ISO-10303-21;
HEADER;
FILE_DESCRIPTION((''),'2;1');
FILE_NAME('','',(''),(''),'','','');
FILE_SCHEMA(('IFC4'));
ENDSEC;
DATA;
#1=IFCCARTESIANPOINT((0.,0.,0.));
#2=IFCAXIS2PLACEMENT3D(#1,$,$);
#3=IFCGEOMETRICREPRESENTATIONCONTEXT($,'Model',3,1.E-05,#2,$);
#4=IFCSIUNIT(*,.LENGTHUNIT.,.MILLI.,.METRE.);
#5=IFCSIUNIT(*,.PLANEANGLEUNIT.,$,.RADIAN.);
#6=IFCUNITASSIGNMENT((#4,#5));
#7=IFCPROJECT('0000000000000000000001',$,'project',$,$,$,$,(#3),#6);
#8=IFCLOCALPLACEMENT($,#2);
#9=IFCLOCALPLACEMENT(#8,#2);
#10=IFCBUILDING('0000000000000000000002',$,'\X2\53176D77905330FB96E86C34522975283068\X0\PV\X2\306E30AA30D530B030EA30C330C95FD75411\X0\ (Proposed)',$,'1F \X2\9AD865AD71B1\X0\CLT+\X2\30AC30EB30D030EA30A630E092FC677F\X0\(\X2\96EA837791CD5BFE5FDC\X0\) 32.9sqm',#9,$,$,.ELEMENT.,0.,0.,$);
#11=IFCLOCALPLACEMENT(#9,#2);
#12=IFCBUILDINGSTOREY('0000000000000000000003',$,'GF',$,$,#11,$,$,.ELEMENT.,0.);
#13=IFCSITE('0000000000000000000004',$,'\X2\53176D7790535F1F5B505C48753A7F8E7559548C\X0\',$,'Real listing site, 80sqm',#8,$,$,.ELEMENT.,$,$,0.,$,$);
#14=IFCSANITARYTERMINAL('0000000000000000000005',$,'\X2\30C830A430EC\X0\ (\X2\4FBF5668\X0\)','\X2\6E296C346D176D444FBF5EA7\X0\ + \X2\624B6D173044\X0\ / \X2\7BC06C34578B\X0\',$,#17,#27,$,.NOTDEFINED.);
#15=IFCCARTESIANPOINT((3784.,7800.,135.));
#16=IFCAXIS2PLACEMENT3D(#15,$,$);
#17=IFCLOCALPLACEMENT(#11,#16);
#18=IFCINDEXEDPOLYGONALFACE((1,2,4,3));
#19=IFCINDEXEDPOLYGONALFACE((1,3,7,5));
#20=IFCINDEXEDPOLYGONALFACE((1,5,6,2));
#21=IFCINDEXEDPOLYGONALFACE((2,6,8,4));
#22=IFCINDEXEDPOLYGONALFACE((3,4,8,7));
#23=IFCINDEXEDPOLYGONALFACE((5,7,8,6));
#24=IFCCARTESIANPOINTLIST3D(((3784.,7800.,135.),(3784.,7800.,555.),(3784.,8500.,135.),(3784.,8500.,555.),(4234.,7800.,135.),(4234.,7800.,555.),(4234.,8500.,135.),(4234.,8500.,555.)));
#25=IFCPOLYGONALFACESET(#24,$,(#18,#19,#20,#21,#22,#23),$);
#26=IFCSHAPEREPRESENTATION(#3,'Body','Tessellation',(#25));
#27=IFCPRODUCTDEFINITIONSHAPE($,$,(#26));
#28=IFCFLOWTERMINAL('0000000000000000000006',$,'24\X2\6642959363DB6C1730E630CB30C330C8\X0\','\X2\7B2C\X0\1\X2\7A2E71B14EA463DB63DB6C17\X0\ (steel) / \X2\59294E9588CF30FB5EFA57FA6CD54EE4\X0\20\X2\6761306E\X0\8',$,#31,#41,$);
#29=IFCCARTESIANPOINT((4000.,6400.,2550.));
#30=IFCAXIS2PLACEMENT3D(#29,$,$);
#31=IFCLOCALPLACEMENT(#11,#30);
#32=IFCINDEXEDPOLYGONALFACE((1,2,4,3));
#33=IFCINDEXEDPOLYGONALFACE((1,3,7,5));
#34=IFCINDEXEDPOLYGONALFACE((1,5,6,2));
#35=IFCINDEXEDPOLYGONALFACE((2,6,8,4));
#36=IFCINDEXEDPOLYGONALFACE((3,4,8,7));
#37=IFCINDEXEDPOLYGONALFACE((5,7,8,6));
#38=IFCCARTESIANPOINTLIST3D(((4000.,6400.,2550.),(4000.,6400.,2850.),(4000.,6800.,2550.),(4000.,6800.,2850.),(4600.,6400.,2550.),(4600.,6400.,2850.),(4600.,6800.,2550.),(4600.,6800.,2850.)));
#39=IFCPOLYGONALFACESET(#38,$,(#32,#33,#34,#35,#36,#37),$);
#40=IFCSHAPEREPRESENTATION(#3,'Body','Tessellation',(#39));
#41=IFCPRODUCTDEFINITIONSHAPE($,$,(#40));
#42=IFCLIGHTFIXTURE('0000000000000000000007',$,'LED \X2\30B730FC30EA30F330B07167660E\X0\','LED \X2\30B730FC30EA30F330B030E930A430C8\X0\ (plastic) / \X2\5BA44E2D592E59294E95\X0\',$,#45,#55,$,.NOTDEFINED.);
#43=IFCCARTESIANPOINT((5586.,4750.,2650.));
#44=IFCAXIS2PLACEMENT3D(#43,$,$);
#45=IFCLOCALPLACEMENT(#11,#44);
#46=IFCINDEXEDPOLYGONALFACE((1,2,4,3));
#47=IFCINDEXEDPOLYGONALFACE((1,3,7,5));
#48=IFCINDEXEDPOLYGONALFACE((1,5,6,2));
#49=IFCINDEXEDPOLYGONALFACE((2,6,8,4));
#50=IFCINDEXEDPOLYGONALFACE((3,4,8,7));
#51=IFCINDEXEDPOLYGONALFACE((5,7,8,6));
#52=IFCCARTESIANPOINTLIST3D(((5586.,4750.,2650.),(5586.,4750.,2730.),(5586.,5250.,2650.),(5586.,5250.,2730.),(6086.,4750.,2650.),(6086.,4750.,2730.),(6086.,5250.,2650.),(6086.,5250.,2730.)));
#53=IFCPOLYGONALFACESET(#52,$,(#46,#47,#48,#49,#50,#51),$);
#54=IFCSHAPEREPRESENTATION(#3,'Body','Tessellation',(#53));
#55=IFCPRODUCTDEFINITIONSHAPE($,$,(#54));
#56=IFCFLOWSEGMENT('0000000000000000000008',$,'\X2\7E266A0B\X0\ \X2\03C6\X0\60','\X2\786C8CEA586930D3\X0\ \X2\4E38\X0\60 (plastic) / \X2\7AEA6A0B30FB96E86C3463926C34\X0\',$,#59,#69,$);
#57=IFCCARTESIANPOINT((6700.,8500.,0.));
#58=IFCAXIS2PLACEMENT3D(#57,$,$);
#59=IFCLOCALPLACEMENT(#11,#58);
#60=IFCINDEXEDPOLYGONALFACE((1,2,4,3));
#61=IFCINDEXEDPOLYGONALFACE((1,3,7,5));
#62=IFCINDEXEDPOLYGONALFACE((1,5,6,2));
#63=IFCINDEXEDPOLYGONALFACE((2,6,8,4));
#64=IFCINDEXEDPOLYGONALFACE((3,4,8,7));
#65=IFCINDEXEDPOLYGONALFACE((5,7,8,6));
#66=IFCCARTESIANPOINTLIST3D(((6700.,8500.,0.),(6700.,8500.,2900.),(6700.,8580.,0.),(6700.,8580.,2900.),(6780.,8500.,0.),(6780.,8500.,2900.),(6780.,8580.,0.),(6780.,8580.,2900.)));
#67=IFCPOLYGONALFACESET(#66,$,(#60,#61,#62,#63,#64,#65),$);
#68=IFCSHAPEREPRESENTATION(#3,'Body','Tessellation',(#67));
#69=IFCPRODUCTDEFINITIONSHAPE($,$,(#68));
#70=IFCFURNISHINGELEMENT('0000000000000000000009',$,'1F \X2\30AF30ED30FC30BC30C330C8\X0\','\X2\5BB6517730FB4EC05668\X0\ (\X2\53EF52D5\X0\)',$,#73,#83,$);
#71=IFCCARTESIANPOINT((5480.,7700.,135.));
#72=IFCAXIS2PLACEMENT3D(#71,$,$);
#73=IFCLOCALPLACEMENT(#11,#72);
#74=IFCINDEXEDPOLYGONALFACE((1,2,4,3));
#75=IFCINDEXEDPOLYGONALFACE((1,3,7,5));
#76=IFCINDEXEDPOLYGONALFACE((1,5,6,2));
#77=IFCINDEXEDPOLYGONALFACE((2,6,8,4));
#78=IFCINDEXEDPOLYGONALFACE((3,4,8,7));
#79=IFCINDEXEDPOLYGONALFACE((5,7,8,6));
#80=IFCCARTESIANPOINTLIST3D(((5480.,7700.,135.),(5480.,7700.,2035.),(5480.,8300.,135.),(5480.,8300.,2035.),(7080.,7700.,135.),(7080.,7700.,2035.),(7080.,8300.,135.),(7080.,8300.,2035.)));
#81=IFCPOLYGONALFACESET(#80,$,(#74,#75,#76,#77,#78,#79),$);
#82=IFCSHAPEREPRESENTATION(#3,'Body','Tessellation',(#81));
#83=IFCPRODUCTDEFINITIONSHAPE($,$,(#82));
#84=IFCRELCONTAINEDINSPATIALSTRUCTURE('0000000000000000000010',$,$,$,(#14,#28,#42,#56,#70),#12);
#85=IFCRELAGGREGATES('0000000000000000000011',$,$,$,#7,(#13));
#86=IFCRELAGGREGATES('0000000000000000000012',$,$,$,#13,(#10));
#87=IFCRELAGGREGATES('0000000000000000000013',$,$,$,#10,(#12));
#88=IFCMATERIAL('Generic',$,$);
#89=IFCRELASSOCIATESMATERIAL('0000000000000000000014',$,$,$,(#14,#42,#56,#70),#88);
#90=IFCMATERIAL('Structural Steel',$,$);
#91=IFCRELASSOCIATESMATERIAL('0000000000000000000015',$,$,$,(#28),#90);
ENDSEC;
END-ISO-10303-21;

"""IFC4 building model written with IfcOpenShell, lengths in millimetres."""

from ifc_helpers import new_model, si_unit, frame, frame_2d, origin, place, context, project, spatial, rectangle, extrude, material, element, save


model = new_model("IFC4")

# Units and contexts
model_context = context("Model", 3, precision=1e-05, world=origin())
ifc_project = project(units=[si_unit("LENGTHUNIT", "METRE", prefix="MILLI"), si_unit("PLANEANGLEUNIT", "RADIAN")], contexts=[model_context])

# Site, building, storey
site_placement = place(None, origin())
site = spatial("IfcSite", under=ifc_project, at=site_placement, Name="北海道弟子屈町美留和", ObjectType="Real listing site, 80sqm", CompositionType="ELEMENT", RefElevation=0.0)
building_placement = place(site_placement, origin())
building = spatial("IfcBuilding", under=site, at=building_placement, Name="北海道・雨水利用とPVのオフグリッド志向 (Proposed)", ObjectType="1F 高断熱CLT+ガルバリウム鋼板(雪荷重対応) 32.9sqm", CompositionType="ELEMENT", ElevationOfRefHeight=0.0, ElevationOfTerrain=0.0)
storey_placement = place(building_placement, origin())
storey = spatial("IfcBuildingStorey", under=building, at=storey_placement, Name="GF", CompositionType="ELEMENT", Elevation=0.0)

# Shared definitions
ifc_material_1 = material(Name="Generic")

# Sanitary terminal
sanitary_terminal_placement = place(storey_placement, frame((3784.0, 7800.0, 135.0)))
element("IfcSanitaryTerminal", 1, at=sanitary_terminal_placement, inside=storey, material=ifc_material_1, Name="トイレ (便器)", Description="温水洗浄便座 + 手洗い / 節水型", PredefinedType="NOTDEFINED", context=model_context, shape_type="SweptSolid", body=[
    extrude(rectangle(XDim=450.0, YDim=700.0, at=frame_2d((225.0, 350.0))), frame((3784.0, 7800.0, 135.0)), (0.0, 0.0, 1.0), 420.0),
])

# Flow terminal
ifc_material_2 = material(Name="Structural Steel")
flow_terminal_placement = place(storey_placement, frame((4000.0, 6400.0, 2550.0)))
element("IfcFlowTerminal", 2, at=flow_terminal_placement, inside=storey, material=ifc_material_2, Name="24時間換気ユニット", Description="第1種熱交換換気 (steel) / 天井裏・建基法令20条の8", context=model_context, shape_type="SweptSolid", body=[
    extrude(rectangle(XDim=600.0, YDim=400.0, at=frame_2d((300.0, 200.0))), frame((4000.0, 6400.0, 2550.0)), (0.0, 0.0, 1.0), 300.0),
])

# Light fixture
light_fixture_placement = place(storey_placement, frame((5586.0, 4750.0, 2650.0)))
element("IfcLightFixture", 3, at=light_fixture_placement, inside=storey, material=ifc_material_1, Name="LED シーリング照明", Description="LED シーリングライト (plastic) / 室中央天井", PredefinedType="NOTDEFINED", context=model_context, shape_type="SweptSolid", body=[
    extrude(rectangle(XDim=500.0, YDim=500.0, at=frame_2d((250.0, 250.0))), frame((5586.0, 4750.0, 2650.0)), (0.0, 0.0, 1.0), 80.0),
])

# Flow segment
flow_segment_placement = place(storey_placement, frame((6700.0, 8500.0, 0.0)))
element("IfcFlowSegment", 4, at=flow_segment_placement, inside=storey, material=ifc_material_1, Name="縦樋 φ60", Description="硬質塩ビ 丸60 (plastic) / 竪樋・雨水排水", context=model_context, shape_type="SweptSolid", body=[
    extrude(rectangle(XDim=80.0, YDim=80.0, at=frame_2d((40.0, 40.0))), frame((6700.0, 8500.0, 0.0)), (0.0, 0.0, 1.0), 2900.0),
])

# Furnishing element
furnishing_placement = place(storey_placement, frame((5480.0, 7700.0, 135.0)))
element("IfcFurnishingElement", 5, at=furnishing_placement, inside=storey, material=ifc_material_1, Name="1F クローゼット", Description="家具・什器 (可動)", context=model_context, shape_type="SweptSolid", body=[
    extrude(rectangle(XDim=1600.0, YDim=600.0, at=frame_2d((800.0, 300.0))), frame((5480.0, 7700.0, 135.0)), (0.0, 0.0, 1.0), 1900.0),
])

save(model, "model.ifc")
